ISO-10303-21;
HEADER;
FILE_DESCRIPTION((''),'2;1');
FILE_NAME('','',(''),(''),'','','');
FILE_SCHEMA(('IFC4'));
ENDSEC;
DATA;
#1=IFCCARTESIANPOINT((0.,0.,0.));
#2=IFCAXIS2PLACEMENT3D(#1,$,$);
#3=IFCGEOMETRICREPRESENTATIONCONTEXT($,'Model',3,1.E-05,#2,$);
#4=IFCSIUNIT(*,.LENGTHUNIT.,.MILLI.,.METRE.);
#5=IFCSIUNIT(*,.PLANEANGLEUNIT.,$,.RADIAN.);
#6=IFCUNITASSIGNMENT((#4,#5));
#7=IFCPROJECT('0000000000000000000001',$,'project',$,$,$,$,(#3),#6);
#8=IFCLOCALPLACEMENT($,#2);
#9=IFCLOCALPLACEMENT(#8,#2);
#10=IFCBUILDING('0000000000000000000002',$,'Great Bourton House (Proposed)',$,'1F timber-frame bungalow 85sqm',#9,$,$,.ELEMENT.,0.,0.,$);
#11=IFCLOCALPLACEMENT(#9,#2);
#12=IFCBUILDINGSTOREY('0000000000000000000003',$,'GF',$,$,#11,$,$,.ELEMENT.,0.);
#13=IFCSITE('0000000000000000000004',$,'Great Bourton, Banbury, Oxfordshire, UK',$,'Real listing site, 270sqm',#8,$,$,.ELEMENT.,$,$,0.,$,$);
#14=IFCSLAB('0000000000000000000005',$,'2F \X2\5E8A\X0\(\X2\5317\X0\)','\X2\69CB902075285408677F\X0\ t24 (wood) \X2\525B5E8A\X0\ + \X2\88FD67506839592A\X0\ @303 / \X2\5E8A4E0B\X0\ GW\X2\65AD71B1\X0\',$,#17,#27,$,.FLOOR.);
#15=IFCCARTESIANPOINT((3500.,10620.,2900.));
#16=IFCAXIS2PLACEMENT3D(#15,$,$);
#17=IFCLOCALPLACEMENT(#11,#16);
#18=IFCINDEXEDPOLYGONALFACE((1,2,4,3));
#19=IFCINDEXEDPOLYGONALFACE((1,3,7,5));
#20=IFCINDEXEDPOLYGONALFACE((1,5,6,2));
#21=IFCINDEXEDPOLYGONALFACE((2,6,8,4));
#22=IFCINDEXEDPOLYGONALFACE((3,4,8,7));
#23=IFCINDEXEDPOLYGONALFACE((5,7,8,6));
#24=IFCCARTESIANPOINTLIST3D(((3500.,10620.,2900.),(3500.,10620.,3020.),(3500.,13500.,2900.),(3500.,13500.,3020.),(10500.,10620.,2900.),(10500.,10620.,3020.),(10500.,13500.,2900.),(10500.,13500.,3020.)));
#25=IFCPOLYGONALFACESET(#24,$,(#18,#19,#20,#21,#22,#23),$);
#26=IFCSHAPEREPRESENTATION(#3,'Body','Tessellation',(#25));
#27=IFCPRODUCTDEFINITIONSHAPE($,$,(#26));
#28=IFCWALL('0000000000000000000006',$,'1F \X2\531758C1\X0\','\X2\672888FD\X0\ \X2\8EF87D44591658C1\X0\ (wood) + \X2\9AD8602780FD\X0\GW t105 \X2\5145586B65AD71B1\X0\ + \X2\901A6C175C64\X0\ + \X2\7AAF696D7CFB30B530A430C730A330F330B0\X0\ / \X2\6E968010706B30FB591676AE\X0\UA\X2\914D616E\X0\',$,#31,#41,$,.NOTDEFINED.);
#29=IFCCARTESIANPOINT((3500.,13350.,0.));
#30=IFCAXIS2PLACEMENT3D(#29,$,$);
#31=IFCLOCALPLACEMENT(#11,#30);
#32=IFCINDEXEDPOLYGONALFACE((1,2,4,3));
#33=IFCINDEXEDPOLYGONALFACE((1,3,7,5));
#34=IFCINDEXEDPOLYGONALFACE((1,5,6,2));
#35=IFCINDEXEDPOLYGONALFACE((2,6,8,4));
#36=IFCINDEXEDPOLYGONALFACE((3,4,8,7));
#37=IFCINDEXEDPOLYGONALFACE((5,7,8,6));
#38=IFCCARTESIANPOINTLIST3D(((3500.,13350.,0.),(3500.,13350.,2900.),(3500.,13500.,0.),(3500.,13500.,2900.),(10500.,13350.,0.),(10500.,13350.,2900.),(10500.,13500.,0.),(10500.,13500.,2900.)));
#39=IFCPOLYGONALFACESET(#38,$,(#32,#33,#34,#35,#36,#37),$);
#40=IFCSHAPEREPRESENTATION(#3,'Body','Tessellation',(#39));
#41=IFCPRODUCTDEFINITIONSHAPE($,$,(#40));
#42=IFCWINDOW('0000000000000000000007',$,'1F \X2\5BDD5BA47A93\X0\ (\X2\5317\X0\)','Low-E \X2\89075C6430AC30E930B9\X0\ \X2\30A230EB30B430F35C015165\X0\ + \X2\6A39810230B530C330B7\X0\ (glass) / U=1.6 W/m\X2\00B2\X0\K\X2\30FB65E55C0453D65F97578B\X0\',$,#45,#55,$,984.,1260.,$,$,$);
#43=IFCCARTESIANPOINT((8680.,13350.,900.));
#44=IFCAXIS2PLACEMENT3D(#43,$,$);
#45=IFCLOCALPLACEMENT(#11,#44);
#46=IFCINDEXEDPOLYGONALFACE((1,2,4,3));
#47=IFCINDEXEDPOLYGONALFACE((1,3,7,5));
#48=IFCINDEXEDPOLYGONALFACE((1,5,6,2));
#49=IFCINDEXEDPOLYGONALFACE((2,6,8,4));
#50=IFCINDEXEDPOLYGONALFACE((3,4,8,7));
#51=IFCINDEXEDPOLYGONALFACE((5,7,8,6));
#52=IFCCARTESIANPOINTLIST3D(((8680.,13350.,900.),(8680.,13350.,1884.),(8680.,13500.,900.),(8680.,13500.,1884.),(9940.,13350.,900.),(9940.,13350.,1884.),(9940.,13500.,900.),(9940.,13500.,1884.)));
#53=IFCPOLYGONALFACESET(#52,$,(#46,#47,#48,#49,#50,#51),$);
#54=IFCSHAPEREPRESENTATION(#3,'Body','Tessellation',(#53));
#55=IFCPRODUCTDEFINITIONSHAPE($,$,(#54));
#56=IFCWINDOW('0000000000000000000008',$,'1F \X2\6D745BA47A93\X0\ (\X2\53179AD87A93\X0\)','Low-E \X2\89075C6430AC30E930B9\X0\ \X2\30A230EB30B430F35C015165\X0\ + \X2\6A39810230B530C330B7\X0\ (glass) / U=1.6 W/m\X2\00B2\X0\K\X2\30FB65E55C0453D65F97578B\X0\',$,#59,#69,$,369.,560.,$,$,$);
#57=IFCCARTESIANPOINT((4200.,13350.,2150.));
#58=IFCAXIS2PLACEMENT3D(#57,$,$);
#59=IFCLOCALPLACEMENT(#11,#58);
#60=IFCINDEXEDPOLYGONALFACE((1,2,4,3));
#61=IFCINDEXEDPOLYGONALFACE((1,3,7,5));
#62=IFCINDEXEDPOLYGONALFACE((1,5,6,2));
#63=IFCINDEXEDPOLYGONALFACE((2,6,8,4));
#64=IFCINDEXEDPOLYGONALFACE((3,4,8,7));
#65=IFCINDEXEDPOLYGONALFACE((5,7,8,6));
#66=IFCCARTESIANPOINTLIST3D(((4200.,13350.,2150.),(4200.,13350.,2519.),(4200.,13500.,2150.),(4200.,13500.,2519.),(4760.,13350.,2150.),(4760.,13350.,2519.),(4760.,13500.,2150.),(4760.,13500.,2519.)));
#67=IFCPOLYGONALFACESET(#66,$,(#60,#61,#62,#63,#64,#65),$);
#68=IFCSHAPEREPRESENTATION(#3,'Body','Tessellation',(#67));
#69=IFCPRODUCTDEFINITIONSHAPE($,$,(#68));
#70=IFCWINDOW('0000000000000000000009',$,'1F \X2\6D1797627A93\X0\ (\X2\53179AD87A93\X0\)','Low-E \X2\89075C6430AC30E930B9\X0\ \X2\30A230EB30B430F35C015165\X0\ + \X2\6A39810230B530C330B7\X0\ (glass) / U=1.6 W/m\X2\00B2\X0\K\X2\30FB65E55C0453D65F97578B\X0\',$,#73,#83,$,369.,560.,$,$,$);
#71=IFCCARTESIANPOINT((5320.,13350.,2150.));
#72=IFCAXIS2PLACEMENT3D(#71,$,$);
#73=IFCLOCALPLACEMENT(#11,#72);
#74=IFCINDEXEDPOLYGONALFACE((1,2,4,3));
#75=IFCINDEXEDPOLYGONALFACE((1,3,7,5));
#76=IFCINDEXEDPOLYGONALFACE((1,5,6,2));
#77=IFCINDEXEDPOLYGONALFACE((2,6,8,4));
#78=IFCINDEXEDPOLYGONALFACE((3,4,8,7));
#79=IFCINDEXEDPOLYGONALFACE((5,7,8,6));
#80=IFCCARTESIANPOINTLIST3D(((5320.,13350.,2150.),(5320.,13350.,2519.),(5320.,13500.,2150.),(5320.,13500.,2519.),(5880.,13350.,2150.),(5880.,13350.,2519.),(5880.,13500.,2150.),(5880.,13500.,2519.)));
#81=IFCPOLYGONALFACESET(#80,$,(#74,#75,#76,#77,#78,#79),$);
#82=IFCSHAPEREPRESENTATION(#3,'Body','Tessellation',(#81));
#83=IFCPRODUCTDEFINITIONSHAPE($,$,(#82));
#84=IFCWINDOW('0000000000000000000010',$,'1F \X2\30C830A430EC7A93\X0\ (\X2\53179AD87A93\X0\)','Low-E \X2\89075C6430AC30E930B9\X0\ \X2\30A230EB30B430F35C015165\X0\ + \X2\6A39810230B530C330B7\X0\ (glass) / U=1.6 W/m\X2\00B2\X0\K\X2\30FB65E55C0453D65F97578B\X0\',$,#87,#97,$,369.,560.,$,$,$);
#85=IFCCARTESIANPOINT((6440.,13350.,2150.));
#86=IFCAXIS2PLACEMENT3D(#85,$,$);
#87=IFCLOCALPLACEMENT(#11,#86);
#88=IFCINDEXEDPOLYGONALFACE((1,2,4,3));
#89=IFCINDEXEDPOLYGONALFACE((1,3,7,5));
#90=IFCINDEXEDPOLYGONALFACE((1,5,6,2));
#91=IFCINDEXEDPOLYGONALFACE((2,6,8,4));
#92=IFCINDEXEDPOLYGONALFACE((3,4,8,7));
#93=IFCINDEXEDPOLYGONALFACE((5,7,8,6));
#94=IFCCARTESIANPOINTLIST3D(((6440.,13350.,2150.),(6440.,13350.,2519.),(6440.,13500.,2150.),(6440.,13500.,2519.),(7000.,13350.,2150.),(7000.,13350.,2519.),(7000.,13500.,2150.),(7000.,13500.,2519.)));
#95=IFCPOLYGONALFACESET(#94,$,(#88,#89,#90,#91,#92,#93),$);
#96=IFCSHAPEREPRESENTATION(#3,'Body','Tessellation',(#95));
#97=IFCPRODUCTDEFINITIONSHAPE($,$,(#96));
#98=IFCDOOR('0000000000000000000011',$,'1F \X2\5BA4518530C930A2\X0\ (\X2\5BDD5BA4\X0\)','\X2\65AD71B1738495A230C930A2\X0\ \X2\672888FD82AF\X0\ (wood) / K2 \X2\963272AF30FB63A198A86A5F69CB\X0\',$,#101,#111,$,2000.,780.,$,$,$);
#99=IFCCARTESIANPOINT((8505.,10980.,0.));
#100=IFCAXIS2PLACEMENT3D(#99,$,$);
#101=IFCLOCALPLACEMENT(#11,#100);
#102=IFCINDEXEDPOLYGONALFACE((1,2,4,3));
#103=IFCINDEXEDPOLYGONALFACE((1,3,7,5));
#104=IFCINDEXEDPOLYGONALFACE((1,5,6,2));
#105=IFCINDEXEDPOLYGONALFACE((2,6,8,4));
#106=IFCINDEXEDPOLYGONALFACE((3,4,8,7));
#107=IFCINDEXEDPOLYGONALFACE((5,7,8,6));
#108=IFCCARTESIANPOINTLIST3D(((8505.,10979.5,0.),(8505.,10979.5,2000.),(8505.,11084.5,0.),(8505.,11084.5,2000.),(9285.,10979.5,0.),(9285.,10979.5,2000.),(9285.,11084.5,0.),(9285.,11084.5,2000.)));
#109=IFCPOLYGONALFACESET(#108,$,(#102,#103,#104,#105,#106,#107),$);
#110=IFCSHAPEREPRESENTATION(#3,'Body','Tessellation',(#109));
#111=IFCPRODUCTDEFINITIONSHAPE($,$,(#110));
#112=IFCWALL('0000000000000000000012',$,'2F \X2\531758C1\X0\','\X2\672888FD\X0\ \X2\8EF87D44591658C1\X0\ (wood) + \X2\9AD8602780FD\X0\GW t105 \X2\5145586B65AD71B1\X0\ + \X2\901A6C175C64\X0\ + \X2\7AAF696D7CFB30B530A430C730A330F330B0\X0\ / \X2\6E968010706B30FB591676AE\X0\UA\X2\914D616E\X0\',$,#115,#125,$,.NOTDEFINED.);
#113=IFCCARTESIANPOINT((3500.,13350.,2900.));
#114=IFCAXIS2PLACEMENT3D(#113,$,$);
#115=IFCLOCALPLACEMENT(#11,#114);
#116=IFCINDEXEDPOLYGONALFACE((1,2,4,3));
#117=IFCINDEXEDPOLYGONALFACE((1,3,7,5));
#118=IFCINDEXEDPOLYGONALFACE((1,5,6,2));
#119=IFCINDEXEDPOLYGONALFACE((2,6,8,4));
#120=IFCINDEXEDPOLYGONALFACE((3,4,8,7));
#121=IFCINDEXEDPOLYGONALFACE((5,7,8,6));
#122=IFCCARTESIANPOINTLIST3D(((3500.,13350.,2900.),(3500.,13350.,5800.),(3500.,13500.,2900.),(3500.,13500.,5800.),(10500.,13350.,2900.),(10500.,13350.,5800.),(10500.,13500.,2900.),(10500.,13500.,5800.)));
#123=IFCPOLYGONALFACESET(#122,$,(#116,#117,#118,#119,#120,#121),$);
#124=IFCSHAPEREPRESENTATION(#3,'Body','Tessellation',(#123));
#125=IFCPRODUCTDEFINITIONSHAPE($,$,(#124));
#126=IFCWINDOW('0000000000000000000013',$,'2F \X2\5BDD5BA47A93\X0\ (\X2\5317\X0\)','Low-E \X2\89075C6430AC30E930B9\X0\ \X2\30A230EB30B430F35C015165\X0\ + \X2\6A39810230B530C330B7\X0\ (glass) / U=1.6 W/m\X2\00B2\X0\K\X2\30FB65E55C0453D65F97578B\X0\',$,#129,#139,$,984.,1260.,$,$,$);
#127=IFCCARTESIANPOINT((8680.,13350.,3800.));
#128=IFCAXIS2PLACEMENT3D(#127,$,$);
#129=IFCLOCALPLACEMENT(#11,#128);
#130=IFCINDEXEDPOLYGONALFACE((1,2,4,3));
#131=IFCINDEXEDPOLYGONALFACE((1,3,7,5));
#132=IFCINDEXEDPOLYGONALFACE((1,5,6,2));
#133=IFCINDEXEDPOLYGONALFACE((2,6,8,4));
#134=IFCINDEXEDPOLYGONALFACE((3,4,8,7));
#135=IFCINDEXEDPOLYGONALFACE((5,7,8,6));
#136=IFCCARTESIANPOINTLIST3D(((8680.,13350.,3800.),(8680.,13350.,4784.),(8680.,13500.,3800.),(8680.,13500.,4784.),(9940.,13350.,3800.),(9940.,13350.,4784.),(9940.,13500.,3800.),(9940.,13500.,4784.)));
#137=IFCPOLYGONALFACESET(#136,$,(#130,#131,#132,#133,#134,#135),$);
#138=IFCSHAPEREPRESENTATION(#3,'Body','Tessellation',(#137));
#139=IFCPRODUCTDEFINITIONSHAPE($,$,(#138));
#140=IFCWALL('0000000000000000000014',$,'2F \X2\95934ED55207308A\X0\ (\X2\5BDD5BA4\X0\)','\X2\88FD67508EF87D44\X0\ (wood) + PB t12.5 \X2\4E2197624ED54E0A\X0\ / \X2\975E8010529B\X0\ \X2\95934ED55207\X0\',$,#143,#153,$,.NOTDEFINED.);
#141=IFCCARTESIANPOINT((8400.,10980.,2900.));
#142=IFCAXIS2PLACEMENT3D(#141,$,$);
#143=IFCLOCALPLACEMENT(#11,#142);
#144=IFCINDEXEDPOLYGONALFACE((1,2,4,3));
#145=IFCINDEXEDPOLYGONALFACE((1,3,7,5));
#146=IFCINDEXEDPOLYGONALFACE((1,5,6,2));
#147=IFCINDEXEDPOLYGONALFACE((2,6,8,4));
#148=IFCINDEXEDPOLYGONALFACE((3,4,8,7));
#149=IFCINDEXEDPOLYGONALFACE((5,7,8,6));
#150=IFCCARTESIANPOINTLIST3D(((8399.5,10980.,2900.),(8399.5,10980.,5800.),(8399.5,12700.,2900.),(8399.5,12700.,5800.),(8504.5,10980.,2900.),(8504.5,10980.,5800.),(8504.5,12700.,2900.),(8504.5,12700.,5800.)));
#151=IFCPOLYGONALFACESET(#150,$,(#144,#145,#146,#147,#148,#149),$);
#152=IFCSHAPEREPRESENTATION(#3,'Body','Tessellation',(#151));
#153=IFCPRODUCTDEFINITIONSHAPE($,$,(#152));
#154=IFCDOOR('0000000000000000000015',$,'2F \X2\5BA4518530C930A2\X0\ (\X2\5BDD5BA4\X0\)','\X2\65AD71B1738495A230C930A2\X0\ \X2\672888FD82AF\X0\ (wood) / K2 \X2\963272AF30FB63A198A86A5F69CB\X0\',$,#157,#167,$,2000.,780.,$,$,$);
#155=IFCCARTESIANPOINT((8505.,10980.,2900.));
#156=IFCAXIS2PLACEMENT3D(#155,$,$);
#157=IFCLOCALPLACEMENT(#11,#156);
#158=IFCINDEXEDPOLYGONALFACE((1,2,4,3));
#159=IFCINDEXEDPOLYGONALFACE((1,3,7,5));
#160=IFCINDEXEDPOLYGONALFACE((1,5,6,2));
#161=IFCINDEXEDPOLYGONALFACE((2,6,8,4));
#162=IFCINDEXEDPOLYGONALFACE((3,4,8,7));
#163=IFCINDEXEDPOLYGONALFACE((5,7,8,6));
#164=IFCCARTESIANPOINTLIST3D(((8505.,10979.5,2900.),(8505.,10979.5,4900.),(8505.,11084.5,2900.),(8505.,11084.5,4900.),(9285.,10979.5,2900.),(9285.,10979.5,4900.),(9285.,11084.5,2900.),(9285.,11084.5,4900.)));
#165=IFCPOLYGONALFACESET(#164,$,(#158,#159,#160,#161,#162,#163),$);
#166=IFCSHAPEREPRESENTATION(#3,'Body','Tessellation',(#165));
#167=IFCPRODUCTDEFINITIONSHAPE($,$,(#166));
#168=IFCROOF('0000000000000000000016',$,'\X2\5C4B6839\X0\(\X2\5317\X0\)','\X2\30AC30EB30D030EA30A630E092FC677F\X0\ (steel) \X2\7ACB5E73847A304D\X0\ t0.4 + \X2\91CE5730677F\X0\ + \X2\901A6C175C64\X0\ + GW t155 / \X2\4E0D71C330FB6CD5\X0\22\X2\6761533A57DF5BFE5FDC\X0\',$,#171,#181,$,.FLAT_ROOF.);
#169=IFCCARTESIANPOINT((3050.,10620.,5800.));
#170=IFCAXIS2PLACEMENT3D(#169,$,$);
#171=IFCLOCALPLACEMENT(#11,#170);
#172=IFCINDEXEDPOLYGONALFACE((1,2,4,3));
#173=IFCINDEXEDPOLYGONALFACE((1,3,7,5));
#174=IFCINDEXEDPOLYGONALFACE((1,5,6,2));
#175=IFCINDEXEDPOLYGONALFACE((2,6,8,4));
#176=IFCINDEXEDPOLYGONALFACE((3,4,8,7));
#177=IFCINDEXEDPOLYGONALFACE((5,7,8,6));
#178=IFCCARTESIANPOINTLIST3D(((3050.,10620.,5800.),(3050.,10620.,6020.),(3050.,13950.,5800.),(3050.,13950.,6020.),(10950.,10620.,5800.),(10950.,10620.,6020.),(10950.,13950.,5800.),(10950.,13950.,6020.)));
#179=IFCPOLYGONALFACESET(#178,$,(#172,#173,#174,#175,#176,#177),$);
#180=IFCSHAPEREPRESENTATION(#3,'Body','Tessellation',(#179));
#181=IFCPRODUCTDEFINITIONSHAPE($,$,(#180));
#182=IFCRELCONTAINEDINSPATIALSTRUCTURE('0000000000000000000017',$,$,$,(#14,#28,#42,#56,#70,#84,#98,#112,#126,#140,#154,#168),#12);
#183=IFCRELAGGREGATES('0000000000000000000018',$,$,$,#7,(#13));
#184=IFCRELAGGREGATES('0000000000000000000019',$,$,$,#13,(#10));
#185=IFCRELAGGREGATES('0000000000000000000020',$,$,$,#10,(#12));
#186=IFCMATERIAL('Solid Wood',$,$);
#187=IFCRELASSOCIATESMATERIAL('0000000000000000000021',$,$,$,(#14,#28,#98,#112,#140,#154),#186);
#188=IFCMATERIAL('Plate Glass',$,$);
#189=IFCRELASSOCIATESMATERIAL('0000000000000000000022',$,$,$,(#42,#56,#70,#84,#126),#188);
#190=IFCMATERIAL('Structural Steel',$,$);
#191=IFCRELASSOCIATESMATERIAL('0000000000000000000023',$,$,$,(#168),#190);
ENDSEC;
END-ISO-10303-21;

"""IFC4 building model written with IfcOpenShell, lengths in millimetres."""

from ifc_helpers import new_model, si_unit, frame, frame_2d, origin, place, context, project, spatial, rectangle, extrude, material, element, fill, save


model = new_model("IFC4")

# Units and contexts
model_context = context("Model", 3, precision=1e-05, world=origin())
ifc_project = project(units=[si_unit("LENGTHUNIT", "METRE", prefix="MILLI"), si_unit("PLANEANGLEUNIT", "RADIAN")], contexts=[model_context])

# Site, building, storey
site_placement = place(None, origin())
site = spatial("IfcSite", under=ifc_project, at=site_placement, Name="Great Bourton, Banbury, Oxfordshire, UK", ObjectType="Real listing site, 270sqm", CompositionType="ELEMENT", RefElevation=0.0)
building_placement = place(site_placement, origin())
building = spatial("IfcBuilding", under=site, at=building_placement, Name="Great Bourton House (Proposed)", ObjectType="1F timber-frame bungalow 85sqm", CompositionType="ELEMENT", ElevationOfRefHeight=0.0, ElevationOfTerrain=0.0)
storey_placement = place(building_placement, origin())
storey = spatial("IfcBuildingStorey", under=building, at=storey_placement, Name="GF", CompositionType="ELEMENT", Elevation=0.0)

# Slab
ifc_material_1 = material(Name="Solid Wood")
slab_placement = place(storey_placement, frame((3500.0, 10620.0, 2900.0)))
element("IfcSlab", 1, at=slab_placement, inside=storey, material=ifc_material_1, Name="2F 床(北)", Description="構造用合板 t24 (wood) 剛床 + 製材根太 @303 / 床下 GW断熱", PredefinedType="FLOOR", context=model_context, shape_type="SweptSolid", body=[
    extrude(rectangle(XDim=7000.0, YDim=2880.0, at=frame_2d((3500.0, 1440.0))), frame((3500.0, 10620.0, 2900.0)), (0.0, 0.0, 1.0), 120.0),
])

# Wall, openings, windows
wall_1_placement = place(storey_placement, frame((3500.0, 13350.0, 0.0)))
wall_1 = element("IfcWall", 2, at=wall_1_placement, inside=storey, material=ifc_material_1, Name="1F 北壁", Description="木製 軸組外壁 (wood) + 高性能GW t105 充填断熱 + 通気層 + 窯業系サイディング / 準耐火・外皮UA配慮", PredefinedType="NOTDEFINED", context=model_context, shape_type="SweptSolid", body=[
    extrude(rectangle(XDim=7000.0, YDim=150.0, at=frame_2d((3500.0, 75.0))), frame((3500.0, 13350.0, 0.0)), (0.0, 0.0, 1.0), 2900.0),
])
opening_1_placement = place(storey_placement, frame((8680.0, 13350.0, 900.0)))
opening_1 = element("IfcOpeningElement", 3, at=opening_1_placement, cuts=wall_1, PredefinedType="NOTDEFINED", context=model_context, shape_type="SweptSolid", body=[
    extrude(rectangle(XDim=1260.0, YDim=150.0, at=frame_2d((630.0, 75.0))), frame((8680.0, 13350.0, 900.0)), (0.0, 0.0, 1.0), 984.0),
])
opening_2_placement = place(storey_placement, frame((4200.0, 13350.0, 2150.0)))
opening_2 = element("IfcOpeningElement", 4, at=opening_2_placement, cuts=wall_1, PredefinedType="NOTDEFINED", context=model_context, shape_type="SweptSolid", body=[
    extrude(rectangle(XDim=560.0, YDim=150.0, at=frame_2d((280.0, 75.0))), frame((4200.0, 13350.0, 2150.0)), (0.0, 0.0, 1.0), 369.0),
])
opening_3_placement = place(storey_placement, frame((5320.0, 13350.0, 2150.0)))
opening_3 = element("IfcOpeningElement", 5, at=opening_3_placement, cuts=wall_1, PredefinedType="NOTDEFINED", context=model_context, shape_type="SweptSolid", body=[
    extrude(rectangle(XDim=560.0, YDim=150.0, at=frame_2d((280.0, 75.0))), frame((5320.0, 13350.0, 2150.0)), (0.0, 0.0, 1.0), 369.0),
])
opening_4_placement = place(storey_placement, frame((6440.0, 13350.0, 2150.0)))
opening_4 = element("IfcOpeningElement", 6, at=opening_4_placement, cuts=wall_1, PredefinedType="NOTDEFINED", context=model_context, shape_type="SweptSolid", body=[
    extrude(rectangle(XDim=560.0, YDim=150.0, at=frame_2d((280.0, 75.0))), frame((6440.0, 13350.0, 2150.0)), (0.0, 0.0, 1.0), 369.0),
])
ifc_material_2 = material(Name="Plate Glass")
window_1_placement = place(storey_placement, frame((8680.0, 13350.0, 900.0)))
window_1 = element("IfcWindow", 7, at=window_1_placement, inside=storey, material=ifc_material_2, Name="1F 寝室窓 (北)", Description="Low-E 複層ガラス アルゴン封入 + 樹脂サッシ (glass) / U=1.6 W/m²K・日射取得型", OverallHeight=984.0, OverallWidth=1260.0, context=model_context, shape_type="SweptSolid", body=[
    extrude(rectangle(XDim=1260.0, YDim=150.0, at=frame_2d((630.0, 75.0))), frame((8680.0, 13350.0, 900.0)), (0.0, 0.0, 1.0), 984.0),
])
fill(opening_1, window_1)
window_2_placement = place(storey_placement, frame((4200.0, 13350.0, 2150.0)))
window_2 = element("IfcWindow", 8, at=window_2_placement, inside=storey, material=ifc_material_2, Name="1F 浴室窓 (北高窓)", Description="Low-E 複層ガラス アルゴン封入 + 樹脂サッシ (glass) / U=1.6 W/m²K・日射取得型", OverallHeight=369.0, OverallWidth=560.0, context=model_context, shape_type="SweptSolid", body=[
    extrude(rectangle(XDim=560.0, YDim=150.0, at=frame_2d((280.0, 75.0))), frame((4200.0, 13350.0, 2150.0)), (0.0, 0.0, 1.0), 369.0),
])
fill(opening_2, window_2)
window_3_placement = place(storey_placement, frame((5320.0, 13350.0, 2150.0)))
window_3 = element("IfcWindow", 9, at=window_3_placement, inside=storey, material=ifc_material_2, Name="1F 洗面窓 (北高窓)", Description="Low-E 複層ガラス アルゴン封入 + 樹脂サッシ (glass) / U=1.6 W/m²K・日射取得型", OverallHeight=369.0, OverallWidth=560.0, context=model_context, shape_type="SweptSolid", body=[
    extrude(rectangle(XDim=560.0, YDim=150.0, at=frame_2d((280.0, 75.0))), frame((5320.0, 13350.0, 2150.0)), (0.0, 0.0, 1.0), 369.0),
])
fill(opening_3, window_3)
window_4_placement = place(storey_placement, frame((6440.0, 13350.0, 2150.0)))
window_4 = element("IfcWindow", 10, at=window_4_placement, inside=storey, material=ifc_material_2, Name="1F トイレ窓 (北高窓)", Description="Low-E 複層ガラス アルゴン封入 + 樹脂サッシ (glass) / U=1.6 W/m²K・日射取得型", OverallHeight=369.0, OverallWidth=560.0, context=model_context, shape_type="SweptSolid", body=[
    extrude(rectangle(XDim=560.0, YDim=150.0, at=frame_2d((280.0, 75.0))), frame((6440.0, 13350.0, 2150.0)), (0.0, 0.0, 1.0), 369.0),
])
fill(opening_4, window_4)

# Door
door_1_placement = place(storey_placement, frame((8505.0, 10980.0, 0.0)))
element("IfcDoor", 11, at=door_1_placement, inside=storey, material=ifc_material_1, Name="1F 室内ドア (寝室)", Description="断熱玄関ドア 木製芯 (wood) / K2 防犯・採風機構", OverallHeight=2000.0, OverallWidth=780.0, context=model_context, shape_type="SweptSolid", body=[
    extrude(rectangle(XDim=780.0, YDim=105.0, at=frame_2d((390.0, 52.0))), frame((8505.0, 10980.0, 0.0)), (0.0, 0.0, 1.0), 2000.0),
])

# Wall, opening, window
wall_2_placement = place(storey_placement, frame((3500.0, 13350.0, 2900.0)))
wall_2 = element("IfcWall", 12, at=wall_2_placement, inside=storey, material=ifc_material_1, Name="2F 北壁", Description="木製 軸組外壁 (wood) + 高性能GW t105 充填断熱 + 通気層 + 窯業系サイディング / 準耐火・外皮UA配慮", PredefinedType="NOTDEFINED", context=model_context, shape_type="SweptSolid", body=[
    extrude(rectangle(XDim=7000.0, YDim=150.0, at=frame_2d((3500.0, 75.0))), frame((3500.0, 13350.0, 2900.0)), (0.0, 0.0, 1.0), 2900.0),
])
opening_5_placement = place(storey_placement, frame((8680.0, 13350.0, 3800.0)))
opening_5 = element("IfcOpeningElement", 13, at=opening_5_placement, cuts=wall_2, PredefinedType="NOTDEFINED", context=model_context, shape_type="SweptSolid", body=[
    extrude(rectangle(XDim=1260.0, YDim=150.0, at=frame_2d((630.0, 75.0))), frame((8680.0, 13350.0, 3800.0)), (0.0, 0.0, 1.0), 984.0),
])
window_5_placement = place(storey_placement, frame((8680.0, 13350.0, 3800.0)))
window_5 = element("IfcWindow", 14, at=window_5_placement, inside=storey, material=ifc_material_2, Name="2F 寝室窓 (北)", Description="Low-E 複層ガラス アルゴン封入 + 樹脂サッシ (glass) / U=1.6 W/m²K・日射取得型", OverallHeight=984.0, OverallWidth=1260.0, context=model_context, shape_type="SweptSolid", body=[
    extrude(rectangle(XDim=1260.0, YDim=150.0, at=frame_2d((630.0, 75.0))), frame((8680.0, 13350.0, 3800.0)), (0.0, 0.0, 1.0), 984.0),
])
fill(opening_5, window_5)

# Wall
wall_3_placement = place(storey_placement, frame((8400.0, 10980.0, 2900.0)))
element("IfcWall", 15, at=wall_3_placement, inside=storey, material=ifc_material_1, Name="2F 間仕切り (寝室)", Description="製材軸組 (wood) + PB t12.5 両面仕上 / 非耐力 間仕切", PredefinedType="NOTDEFINED", context=model_context, shape_type="SweptSolid", body=[
    extrude(rectangle(XDim=105.0, YDim=1720.0, at=frame_2d((52.0, 860.0))), frame((8400.0, 10980.0, 2900.0)), (0.0, 0.0, 1.0), 2900.0),
])

# Door
door_2_placement = place(storey_placement, frame((8505.0, 10980.0, 2900.0)))
element("IfcDoor", 16, at=door_2_placement, inside=storey, material=ifc_material_1, Name="2F 室内ドア (寝室)", Description="断熱玄関ドア 木製芯 (wood) / K2 防犯・採風機構", OverallHeight=2000.0, OverallWidth=780.0, context=model_context, shape_type="SweptSolid", body=[
    extrude(rectangle(XDim=780.0, YDim=105.0, at=frame_2d((390.0, 52.0))), frame((8505.0, 10980.0, 2900.0)), (0.0, 0.0, 1.0), 2000.0),
])

# Roof
ifc_material_3 = material(Name="Structural Steel")
roof_placement = place(storey_placement, frame((3050.0, 10620.0, 5800.0)))
element("IfcRoof", 17, at=roof_placement, inside=storey, material=ifc_material_3, Name="屋根(北)", Description="ガルバリウム鋼板 (steel) 立平葺き t0.4 + 野地板 + 通気層 + GW t155 / 不燃・法22条区域対応", PredefinedType="FLAT_ROOF", context=model_context, shape_type="SweptSolid", body=[
    extrude(rectangle(XDim=7900.0, YDim=3330.0, at=frame_2d((3950.0, 1665.0))), frame((3050.0, 10620.0, 5800.0)), (0.0, 0.0, 1.0), 220.0),
])

save(model, "model.ifc")
